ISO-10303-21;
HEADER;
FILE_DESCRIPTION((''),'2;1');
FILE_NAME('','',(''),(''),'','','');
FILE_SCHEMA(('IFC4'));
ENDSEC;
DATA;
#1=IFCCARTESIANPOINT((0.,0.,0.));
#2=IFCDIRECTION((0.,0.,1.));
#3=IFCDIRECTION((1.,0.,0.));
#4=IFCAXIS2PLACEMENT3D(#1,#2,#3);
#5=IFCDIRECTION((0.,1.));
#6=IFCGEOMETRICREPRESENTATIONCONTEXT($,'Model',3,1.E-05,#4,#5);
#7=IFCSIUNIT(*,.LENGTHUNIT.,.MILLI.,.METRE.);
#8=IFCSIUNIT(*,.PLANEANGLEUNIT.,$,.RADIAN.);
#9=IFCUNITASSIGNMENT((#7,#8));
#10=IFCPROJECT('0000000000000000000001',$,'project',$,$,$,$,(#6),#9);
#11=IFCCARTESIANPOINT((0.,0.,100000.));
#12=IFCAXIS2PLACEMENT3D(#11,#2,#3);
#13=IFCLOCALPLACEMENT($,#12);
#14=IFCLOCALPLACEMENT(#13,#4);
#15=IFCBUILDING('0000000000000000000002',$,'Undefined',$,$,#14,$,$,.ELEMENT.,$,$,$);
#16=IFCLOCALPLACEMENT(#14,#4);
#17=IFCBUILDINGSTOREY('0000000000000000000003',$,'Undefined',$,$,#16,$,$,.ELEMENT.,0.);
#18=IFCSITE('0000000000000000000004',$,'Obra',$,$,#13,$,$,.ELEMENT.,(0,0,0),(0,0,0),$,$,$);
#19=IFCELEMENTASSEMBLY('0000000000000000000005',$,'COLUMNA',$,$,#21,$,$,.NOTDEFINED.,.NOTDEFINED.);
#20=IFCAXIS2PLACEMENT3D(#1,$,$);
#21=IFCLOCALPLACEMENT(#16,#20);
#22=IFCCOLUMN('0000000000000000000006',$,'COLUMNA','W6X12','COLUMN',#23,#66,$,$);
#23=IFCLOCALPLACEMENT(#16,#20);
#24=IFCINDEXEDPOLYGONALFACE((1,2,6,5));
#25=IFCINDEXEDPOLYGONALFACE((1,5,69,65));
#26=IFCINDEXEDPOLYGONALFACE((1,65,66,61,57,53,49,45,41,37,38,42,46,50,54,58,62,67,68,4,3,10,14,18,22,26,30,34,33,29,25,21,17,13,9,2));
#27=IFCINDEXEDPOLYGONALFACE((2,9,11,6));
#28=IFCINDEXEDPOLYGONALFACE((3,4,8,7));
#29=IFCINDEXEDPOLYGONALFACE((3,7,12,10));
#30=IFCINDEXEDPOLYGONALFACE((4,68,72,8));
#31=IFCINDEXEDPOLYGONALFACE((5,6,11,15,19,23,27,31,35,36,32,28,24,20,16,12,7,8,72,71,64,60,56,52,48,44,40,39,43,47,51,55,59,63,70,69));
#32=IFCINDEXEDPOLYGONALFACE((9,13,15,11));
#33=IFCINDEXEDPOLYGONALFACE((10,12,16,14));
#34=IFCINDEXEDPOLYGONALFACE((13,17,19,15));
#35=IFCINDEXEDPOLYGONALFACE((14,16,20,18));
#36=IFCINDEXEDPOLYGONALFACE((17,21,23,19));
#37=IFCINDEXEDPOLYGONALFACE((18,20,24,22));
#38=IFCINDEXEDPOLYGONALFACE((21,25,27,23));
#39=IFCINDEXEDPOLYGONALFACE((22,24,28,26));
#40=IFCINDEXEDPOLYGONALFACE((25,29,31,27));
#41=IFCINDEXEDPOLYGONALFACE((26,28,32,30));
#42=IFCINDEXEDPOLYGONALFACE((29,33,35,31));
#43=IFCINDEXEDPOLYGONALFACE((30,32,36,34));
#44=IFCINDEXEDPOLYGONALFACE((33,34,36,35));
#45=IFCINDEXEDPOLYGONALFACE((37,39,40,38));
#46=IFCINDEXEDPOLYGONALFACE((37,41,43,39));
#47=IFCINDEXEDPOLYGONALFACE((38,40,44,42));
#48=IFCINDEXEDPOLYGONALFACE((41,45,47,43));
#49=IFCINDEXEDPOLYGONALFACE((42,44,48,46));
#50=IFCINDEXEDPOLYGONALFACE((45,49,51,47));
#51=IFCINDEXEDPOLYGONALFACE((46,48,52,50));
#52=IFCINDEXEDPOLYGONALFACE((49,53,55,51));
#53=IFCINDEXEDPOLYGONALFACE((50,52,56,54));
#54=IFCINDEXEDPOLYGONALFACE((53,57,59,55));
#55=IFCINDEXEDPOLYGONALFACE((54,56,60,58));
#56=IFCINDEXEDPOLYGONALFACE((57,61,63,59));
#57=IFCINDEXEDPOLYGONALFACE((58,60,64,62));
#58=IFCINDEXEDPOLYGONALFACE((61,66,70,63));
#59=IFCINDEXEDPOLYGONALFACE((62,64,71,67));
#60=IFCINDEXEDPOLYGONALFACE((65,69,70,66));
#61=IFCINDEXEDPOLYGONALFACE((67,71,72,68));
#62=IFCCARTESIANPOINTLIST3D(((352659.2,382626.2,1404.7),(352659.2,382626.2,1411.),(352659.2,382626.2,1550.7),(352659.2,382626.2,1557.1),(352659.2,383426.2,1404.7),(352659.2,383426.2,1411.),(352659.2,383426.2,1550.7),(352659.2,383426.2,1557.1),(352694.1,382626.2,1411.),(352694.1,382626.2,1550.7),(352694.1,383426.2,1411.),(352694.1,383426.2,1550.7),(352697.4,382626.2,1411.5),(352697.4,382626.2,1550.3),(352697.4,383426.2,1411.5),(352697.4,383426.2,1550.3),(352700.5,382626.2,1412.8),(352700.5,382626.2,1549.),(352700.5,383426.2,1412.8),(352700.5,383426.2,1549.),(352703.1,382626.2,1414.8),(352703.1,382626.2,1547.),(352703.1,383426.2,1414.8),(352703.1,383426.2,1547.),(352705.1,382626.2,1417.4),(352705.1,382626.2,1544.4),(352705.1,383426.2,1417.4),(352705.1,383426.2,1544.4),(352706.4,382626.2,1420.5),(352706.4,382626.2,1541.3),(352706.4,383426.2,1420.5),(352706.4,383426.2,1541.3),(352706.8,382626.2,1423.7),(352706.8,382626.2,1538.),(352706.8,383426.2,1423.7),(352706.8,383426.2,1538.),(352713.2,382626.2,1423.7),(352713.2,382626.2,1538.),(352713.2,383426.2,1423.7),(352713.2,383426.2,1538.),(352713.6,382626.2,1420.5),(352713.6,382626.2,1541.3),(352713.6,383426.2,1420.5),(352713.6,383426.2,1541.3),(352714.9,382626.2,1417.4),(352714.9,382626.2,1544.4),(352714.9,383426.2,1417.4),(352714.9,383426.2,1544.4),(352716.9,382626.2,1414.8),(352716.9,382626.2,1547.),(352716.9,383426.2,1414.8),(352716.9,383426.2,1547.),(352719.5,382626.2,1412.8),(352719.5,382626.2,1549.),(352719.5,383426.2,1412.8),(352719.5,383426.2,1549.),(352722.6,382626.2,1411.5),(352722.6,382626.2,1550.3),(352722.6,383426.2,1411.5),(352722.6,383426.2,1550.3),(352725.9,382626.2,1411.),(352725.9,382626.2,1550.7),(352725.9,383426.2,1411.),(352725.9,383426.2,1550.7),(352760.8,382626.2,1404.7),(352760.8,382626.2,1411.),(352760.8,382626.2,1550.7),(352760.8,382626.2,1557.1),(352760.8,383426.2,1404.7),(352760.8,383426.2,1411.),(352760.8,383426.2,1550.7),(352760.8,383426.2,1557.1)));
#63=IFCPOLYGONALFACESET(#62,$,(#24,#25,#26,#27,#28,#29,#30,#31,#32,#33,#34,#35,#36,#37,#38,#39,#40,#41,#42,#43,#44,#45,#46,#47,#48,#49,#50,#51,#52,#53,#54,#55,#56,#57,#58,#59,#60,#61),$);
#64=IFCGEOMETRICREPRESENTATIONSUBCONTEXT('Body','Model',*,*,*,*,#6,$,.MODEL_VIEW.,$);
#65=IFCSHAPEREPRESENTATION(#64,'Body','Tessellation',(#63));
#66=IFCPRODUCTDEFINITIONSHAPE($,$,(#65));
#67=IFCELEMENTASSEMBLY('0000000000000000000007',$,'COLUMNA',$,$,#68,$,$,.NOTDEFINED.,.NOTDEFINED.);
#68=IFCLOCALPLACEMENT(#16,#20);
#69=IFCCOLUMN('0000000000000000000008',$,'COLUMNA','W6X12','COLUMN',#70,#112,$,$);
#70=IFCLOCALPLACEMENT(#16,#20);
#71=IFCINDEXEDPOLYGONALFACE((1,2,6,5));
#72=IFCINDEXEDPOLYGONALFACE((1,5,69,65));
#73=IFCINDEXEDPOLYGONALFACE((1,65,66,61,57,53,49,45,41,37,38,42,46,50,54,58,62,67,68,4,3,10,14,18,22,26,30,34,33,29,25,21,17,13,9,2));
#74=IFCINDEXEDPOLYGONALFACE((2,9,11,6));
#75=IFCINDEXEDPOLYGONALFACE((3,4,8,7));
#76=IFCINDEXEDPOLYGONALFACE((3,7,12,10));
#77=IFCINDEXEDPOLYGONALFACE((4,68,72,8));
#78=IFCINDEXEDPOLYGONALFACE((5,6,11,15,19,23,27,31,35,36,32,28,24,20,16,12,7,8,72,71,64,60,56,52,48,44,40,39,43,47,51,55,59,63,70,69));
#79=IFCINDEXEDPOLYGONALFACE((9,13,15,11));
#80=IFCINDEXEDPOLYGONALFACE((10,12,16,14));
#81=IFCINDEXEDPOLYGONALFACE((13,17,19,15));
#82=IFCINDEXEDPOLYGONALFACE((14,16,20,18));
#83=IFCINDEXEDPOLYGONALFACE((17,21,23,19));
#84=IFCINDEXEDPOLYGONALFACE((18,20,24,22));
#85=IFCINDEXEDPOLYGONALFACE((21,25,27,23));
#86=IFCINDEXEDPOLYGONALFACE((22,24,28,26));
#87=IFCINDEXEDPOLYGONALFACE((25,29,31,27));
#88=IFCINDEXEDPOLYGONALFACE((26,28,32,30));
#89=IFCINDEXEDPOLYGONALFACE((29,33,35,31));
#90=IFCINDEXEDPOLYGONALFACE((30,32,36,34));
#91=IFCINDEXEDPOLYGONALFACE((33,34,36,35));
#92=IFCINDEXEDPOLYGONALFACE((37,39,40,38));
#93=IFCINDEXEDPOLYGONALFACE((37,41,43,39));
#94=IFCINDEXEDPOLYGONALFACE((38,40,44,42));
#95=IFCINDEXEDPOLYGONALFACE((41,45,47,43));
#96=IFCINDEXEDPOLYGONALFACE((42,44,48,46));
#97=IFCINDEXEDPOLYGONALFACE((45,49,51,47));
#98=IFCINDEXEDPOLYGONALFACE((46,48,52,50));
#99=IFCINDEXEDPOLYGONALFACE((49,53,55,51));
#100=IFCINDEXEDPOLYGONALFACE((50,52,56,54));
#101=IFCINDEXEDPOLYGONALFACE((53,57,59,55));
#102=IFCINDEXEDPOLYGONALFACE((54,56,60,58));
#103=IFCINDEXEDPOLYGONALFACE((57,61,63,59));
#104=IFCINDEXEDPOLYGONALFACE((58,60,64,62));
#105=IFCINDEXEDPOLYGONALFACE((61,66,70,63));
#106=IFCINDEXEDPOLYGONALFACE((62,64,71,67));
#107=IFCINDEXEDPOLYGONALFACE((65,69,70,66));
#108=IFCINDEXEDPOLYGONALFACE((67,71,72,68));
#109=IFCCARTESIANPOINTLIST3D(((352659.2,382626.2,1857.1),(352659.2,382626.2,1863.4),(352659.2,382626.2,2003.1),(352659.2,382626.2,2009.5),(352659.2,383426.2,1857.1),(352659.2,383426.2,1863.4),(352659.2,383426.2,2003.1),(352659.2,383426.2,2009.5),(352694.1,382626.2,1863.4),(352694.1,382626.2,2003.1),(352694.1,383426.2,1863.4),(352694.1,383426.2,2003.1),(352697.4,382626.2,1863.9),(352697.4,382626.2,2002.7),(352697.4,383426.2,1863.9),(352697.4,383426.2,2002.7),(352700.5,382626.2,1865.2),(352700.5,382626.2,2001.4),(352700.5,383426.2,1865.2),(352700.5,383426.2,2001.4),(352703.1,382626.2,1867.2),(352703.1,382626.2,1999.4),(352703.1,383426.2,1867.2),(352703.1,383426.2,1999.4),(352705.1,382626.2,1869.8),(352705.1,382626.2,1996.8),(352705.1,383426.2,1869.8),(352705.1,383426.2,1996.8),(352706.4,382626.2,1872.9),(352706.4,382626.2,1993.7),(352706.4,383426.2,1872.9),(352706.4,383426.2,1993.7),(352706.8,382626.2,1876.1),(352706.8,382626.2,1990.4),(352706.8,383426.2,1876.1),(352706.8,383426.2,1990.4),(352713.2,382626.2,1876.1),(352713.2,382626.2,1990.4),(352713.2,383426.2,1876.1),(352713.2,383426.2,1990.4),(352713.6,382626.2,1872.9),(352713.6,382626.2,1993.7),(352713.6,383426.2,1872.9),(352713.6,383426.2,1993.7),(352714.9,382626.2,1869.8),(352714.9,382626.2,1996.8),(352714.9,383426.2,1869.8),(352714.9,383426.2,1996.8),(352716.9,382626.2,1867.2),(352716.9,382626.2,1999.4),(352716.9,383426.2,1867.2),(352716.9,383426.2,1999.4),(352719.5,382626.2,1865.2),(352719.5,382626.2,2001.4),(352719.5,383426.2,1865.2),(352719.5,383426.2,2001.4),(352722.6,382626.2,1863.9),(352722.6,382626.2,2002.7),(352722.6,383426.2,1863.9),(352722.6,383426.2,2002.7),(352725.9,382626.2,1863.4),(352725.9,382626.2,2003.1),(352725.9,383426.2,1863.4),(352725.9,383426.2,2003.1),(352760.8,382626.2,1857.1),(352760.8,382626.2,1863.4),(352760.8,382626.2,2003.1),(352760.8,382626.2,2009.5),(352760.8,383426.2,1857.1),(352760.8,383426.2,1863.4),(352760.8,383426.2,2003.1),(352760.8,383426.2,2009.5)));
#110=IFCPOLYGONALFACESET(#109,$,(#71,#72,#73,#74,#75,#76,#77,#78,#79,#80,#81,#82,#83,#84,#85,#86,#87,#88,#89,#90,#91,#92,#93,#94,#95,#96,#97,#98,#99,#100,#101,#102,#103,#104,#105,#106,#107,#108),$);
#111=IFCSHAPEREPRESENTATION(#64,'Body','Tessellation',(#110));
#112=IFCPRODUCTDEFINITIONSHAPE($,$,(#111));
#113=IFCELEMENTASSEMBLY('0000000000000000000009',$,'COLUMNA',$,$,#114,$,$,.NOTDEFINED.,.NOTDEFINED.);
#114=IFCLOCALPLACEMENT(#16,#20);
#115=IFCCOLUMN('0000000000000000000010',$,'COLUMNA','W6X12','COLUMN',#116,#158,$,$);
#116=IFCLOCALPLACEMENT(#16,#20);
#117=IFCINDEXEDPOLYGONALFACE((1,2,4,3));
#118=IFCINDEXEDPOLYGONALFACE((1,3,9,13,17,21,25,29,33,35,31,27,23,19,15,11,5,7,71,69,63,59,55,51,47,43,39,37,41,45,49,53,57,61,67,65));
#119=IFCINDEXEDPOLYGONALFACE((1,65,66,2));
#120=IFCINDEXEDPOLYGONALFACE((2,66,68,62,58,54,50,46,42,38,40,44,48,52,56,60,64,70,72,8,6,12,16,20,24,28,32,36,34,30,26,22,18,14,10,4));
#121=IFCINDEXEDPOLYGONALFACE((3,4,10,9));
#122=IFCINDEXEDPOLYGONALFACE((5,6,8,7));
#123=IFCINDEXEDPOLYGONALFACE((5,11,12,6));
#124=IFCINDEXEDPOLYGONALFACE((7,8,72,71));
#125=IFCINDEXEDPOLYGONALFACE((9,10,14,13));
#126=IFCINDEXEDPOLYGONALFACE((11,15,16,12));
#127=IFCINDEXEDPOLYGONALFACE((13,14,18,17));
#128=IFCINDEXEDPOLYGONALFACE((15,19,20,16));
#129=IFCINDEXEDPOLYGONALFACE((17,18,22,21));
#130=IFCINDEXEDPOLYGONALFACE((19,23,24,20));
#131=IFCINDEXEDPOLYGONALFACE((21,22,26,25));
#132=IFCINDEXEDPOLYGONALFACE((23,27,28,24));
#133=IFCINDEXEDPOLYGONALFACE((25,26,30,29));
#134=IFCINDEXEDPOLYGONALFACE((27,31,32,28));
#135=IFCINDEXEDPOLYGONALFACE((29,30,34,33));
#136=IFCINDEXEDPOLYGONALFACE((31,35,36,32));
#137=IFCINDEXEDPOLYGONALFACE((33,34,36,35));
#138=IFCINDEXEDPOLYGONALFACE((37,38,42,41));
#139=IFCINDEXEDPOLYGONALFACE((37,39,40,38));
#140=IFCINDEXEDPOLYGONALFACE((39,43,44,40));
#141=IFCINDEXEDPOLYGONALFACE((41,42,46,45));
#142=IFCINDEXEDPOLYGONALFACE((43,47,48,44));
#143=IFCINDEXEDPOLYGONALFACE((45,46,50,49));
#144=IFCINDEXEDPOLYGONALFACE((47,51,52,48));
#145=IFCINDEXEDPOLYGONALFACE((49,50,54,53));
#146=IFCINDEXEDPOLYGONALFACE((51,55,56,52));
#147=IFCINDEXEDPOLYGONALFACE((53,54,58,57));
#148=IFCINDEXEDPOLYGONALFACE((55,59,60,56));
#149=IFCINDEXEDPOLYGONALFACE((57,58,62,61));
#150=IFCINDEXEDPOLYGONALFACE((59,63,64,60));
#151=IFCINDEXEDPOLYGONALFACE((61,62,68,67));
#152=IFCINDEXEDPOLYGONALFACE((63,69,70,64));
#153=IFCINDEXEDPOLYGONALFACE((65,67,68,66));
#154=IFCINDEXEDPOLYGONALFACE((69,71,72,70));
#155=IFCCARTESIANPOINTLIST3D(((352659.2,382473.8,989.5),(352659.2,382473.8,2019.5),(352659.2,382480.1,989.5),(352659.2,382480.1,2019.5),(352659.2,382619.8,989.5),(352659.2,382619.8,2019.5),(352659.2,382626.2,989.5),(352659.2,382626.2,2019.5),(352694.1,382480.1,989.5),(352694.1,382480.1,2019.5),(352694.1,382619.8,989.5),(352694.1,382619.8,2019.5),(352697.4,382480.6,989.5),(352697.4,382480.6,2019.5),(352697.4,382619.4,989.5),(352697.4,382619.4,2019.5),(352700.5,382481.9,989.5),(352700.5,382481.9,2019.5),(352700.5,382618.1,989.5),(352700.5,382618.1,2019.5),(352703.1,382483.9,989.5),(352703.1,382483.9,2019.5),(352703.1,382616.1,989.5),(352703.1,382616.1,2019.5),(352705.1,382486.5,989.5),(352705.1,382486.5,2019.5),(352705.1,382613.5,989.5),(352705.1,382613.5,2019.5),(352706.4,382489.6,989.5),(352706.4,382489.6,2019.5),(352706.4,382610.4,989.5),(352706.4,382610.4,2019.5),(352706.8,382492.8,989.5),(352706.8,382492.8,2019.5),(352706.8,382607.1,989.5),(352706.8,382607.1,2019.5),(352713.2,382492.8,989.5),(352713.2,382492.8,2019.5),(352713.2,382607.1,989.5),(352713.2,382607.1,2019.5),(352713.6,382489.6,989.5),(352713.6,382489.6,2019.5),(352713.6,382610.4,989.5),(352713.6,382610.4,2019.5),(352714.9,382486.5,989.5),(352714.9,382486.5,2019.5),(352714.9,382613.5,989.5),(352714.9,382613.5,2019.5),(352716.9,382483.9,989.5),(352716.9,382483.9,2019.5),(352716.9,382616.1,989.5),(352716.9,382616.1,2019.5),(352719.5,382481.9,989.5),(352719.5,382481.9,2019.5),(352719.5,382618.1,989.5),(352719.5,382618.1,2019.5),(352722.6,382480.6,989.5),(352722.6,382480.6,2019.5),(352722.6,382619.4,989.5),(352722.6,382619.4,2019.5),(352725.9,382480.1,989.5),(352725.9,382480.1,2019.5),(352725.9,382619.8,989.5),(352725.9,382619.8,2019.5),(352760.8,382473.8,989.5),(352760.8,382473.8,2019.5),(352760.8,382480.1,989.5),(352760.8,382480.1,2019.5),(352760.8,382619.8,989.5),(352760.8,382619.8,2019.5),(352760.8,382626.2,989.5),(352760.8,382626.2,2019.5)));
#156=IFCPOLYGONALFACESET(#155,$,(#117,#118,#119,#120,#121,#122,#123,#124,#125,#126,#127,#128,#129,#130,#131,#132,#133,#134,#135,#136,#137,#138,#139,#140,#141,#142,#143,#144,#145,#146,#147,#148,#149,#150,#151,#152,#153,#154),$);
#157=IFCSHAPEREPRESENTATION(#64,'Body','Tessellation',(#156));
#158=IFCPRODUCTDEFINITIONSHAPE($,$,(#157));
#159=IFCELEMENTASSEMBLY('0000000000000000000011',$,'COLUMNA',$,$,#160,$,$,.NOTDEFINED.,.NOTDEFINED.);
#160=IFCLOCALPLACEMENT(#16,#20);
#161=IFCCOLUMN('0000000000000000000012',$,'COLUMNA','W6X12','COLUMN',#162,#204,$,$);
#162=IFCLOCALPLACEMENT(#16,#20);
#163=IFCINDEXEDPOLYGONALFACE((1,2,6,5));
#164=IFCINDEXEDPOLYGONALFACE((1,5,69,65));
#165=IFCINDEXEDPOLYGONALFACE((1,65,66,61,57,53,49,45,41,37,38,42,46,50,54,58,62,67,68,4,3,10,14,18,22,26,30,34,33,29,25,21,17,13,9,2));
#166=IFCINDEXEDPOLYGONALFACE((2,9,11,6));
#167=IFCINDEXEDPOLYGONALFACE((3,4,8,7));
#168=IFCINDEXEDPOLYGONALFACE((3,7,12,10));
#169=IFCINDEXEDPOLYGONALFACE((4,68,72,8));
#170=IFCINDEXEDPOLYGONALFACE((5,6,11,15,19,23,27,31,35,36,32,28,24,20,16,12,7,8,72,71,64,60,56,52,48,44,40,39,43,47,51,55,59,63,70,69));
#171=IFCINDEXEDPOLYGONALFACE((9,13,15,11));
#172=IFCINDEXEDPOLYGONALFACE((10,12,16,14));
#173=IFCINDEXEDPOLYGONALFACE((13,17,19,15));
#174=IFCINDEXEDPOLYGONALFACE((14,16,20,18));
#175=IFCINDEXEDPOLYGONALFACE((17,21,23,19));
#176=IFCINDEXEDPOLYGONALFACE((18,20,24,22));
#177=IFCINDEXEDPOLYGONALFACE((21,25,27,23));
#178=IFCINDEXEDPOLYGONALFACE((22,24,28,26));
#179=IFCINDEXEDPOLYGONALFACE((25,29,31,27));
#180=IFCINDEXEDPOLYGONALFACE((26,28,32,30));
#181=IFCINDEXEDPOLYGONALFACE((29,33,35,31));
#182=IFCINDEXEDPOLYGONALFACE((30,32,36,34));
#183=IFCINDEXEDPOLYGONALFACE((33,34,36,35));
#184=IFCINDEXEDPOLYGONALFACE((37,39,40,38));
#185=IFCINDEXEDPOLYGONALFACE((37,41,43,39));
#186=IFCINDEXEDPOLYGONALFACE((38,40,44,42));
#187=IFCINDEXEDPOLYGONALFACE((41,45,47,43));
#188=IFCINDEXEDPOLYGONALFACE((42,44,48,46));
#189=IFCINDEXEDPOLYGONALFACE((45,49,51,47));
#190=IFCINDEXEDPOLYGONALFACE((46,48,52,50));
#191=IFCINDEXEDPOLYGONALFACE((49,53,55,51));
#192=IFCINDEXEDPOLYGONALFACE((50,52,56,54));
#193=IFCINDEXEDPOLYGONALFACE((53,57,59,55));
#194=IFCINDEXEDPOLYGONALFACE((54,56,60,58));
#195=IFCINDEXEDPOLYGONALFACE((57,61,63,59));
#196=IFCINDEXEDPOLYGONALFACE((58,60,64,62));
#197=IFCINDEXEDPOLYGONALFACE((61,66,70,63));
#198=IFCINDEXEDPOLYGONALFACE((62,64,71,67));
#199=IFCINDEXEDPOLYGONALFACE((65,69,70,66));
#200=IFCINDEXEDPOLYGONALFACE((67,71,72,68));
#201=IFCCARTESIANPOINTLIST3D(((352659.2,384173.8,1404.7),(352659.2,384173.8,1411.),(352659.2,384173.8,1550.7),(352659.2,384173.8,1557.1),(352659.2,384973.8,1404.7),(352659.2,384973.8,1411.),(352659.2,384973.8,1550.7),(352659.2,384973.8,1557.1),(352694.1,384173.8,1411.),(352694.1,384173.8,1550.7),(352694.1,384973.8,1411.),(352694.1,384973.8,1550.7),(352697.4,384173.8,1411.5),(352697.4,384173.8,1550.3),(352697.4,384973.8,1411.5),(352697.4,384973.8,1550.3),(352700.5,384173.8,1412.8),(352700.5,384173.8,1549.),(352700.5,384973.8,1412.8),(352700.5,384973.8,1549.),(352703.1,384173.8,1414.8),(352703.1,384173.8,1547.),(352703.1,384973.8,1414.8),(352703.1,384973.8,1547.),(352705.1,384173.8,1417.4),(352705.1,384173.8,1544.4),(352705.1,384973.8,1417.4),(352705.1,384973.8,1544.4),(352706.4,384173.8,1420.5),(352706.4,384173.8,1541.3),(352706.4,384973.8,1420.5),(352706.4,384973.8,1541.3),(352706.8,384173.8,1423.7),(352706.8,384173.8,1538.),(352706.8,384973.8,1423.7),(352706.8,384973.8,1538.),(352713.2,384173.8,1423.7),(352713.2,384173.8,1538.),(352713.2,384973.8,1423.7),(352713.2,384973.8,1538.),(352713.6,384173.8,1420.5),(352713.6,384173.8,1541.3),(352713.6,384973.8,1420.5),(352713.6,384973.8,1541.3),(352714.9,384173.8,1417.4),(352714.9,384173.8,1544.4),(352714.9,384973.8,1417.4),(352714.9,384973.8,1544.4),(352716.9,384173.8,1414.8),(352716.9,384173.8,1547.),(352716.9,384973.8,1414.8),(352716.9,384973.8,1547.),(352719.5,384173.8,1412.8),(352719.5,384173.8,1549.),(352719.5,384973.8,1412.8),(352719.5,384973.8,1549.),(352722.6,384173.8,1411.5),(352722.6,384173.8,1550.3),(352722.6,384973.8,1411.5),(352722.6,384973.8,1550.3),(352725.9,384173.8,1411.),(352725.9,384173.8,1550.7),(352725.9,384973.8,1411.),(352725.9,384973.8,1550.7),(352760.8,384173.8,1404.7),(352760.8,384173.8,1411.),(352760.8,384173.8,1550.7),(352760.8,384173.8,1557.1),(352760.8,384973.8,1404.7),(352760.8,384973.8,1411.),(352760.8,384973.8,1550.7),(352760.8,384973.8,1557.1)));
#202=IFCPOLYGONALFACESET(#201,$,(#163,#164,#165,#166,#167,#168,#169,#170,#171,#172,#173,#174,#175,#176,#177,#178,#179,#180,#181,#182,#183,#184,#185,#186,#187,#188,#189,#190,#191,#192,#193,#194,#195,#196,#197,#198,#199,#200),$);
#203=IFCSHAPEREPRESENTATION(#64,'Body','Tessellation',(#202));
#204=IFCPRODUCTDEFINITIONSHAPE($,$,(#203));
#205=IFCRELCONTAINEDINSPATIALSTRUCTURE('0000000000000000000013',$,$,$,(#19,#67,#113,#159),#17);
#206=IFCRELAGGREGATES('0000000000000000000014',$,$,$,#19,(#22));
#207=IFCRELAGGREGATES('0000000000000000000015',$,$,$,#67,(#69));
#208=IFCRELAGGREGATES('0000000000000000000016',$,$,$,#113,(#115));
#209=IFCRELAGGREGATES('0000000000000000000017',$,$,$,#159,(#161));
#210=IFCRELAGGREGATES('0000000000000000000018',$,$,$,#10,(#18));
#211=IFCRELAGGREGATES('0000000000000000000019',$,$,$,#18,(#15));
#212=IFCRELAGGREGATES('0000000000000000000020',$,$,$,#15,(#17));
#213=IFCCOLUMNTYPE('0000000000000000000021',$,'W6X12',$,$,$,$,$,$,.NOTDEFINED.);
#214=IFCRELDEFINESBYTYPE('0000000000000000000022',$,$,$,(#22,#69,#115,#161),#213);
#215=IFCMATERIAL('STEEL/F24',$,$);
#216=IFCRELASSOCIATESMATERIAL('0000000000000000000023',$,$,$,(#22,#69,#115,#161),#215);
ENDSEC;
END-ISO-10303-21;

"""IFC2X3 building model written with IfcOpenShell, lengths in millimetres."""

from ifc_helpers import new_model, si_unit, direction, frame, origin_with_axes, origin_2d_with_axis, place, context, subcontext, project, spatial, i_section, extrude, material, type_object, element, aggregate, save


model = new_model("IFC2X3")

# Units and contexts
model_context = context("Model", 3, precision=1e-05, world=origin_with_axes(), true_north=direction((0.0, 1.0)))
body_context = subcontext(model_context, "Body", "Model", "MODEL_VIEW")
ifc_project = project(units=[si_unit("LENGTHUNIT", "METRE", prefix="MILLI"), si_unit("PLANEANGLEUNIT", "RADIAN")], contexts=[model_context])

# Site, building, storey
site_placement = place(None, frame((0.0, 0.0, 100000.0), z_axis=(0.0, 0.0, 1.0), x_axis=(1.0, 0.0, 0.0)))
site = spatial("IfcSite", under=ifc_project, at=site_placement, Name="Obra", CompositionType="ELEMENT", RefLatitude=(0, 0, 0), RefLongitude=(0, 0, 0))
building_placement = place(site_placement, origin_with_axes())
building = spatial("IfcBuilding", under=site, at=building_placement, Name="Undefined", CompositionType="ELEMENT")
storey_placement = place(building_placement, origin_with_axes())
storey = spatial("IfcBuildingStorey", under=building, at=storey_placement, Name="Undefined", CompositionType="ELEMENT", Elevation=0.0)

# Element assemblies, columns
ifc_material_1 = material(Name="STEEL/F24")
assembly_1_placement = place(storey_placement, origin_with_axes())
assembly_1 = element("IfcElementAssembly", 1, at=assembly_1_placement, inside=storey, Name="COLUMNA", AssemblyPlace="NOTDEFINED", PredefinedType="NOTDEFINED")
column_type_1 = type_object("IfcColumnType", Name="W6X12", PredefinedType="NOTDEFINED")
column_1_placement = place(assembly_1_placement, frame((352710.0, 382626.2, 1480.9), z_axis=(0.0, 1.0, 0.0), x_axis=(0.0, 0.0, -1.0)))
column_1 = element("IfcColumn", 2, at=column_1_placement, type_object=column_type_1, material=ifc_material_1, Name="COLUMNA", Description="W6X12", ObjectType="COLUMN", context=body_context, shape_type="SweptSolid", body=[
    extrude(i_section(OverallWidth=101.6, OverallDepth=152.4, WebThickness=6.3, FlangeThickness=6.3, FilletRadius=12.7, at=origin_2d_with_axis()), frame((0.0, 0.0, 800.0), z_axis=(0.0, 0.0, -1.0), x_axis=(0.0, 1.0, 0.0)), (0.0, 0.0, 1.0), 800.0),
])
aggregate(assembly_1, [column_1])
assembly_2_placement = place(storey_placement, origin_with_axes())
assembly_2 = element("IfcElementAssembly", 3, at=assembly_2_placement, inside=storey, Name="COLUMNA", AssemblyPlace="NOTDEFINED", PredefinedType="NOTDEFINED")
column_2_placement = place(assembly_2_placement, frame((352710.0, 382626.2, 1933.3), z_axis=(0.0, 1.0, 0.0), x_axis=(0.0, 0.0, -1.0)))
column_2 = element("IfcColumn", 4, at=column_2_placement, type_object=column_type_1, material=ifc_material_1, Name="COLUMNA", Description="W6X12", ObjectType="COLUMN", context=body_context, shape_type="SweptSolid", body=[
    extrude(i_section(OverallWidth=101.6, OverallDepth=152.4, WebThickness=6.3, FlangeThickness=6.3, FilletRadius=12.7, at=origin_2d_with_axis()), frame((0.0, 0.0, 800.0), z_axis=(0.0, 0.0, -1.0), x_axis=(0.0, 1.0, 0.0)), (0.0, 0.0, 1.0), 800.0),
])
aggregate(assembly_2, [column_2])
assembly_3_placement = place(storey_placement, origin_with_axes())
assembly_3 = element("IfcElementAssembly", 5, at=assembly_3_placement, inside=storey, Name="COLUMNA", AssemblyPlace="NOTDEFINED", PredefinedType="NOTDEFINED")
column_3_placement = place(assembly_3_placement, frame((352710.0, 382550.0, 989.5), z_axis=(0.0, 0.0, 1.0), x_axis=(0.0, -1.0, 0.0)))
column_3 = element("IfcColumn", 6, at=column_3_placement, type_object=column_type_1, material=ifc_material_1, Name="COLUMNA", Description="W6X12", ObjectType="COLUMN", context=body_context, shape_type="SweptSolid", body=[
    extrude(i_section(OverallWidth=101.6, OverallDepth=152.4, WebThickness=6.3, FlangeThickness=6.3, FilletRadius=12.7, at=origin_2d_with_axis()), frame((0.0, 0.0, 1030.0), z_axis=(0.0, 0.0, -1.0), x_axis=(0.0, 1.0, 0.0)), (0.0, 0.0, 1.0), 1030.0),
])
aggregate(assembly_3, [column_3])
assembly_4_placement = place(storey_placement, origin_with_axes())
assembly_4 = element("IfcElementAssembly", 7, at=assembly_4_placement, inside=storey, Name="COLUMNA", AssemblyPlace="NOTDEFINED", PredefinedType="NOTDEFINED")
column_4_placement = place(assembly_4_placement, frame((352710.0, 384973.8, 1480.9), z_axis=(0.0, -1.0, 0.0), x_axis=(0.0, 0.0, -1.0)))
column_4 = element("IfcColumn", 8, at=column_4_placement, type_object=column_type_1, material=ifc_material_1, Name="COLUMNA", Description="W6X12", ObjectType="COLUMN", context=body_context, shape_type="SweptSolid", body=[
    extrude(i_section(OverallWidth=101.6, OverallDepth=152.4, WebThickness=6.3, FlangeThickness=6.3, FilletRadius=12.7, at=origin_2d_with_axis()), frame((0.0, 0.0, 800.0), z_axis=(0.0, 0.0, -1.0), x_axis=(0.0, 1.0, 0.0)), (0.0, 0.0, 1.0), 800.0),
])
aggregate(assembly_4, [column_4])

save(model, "model.ifc")
